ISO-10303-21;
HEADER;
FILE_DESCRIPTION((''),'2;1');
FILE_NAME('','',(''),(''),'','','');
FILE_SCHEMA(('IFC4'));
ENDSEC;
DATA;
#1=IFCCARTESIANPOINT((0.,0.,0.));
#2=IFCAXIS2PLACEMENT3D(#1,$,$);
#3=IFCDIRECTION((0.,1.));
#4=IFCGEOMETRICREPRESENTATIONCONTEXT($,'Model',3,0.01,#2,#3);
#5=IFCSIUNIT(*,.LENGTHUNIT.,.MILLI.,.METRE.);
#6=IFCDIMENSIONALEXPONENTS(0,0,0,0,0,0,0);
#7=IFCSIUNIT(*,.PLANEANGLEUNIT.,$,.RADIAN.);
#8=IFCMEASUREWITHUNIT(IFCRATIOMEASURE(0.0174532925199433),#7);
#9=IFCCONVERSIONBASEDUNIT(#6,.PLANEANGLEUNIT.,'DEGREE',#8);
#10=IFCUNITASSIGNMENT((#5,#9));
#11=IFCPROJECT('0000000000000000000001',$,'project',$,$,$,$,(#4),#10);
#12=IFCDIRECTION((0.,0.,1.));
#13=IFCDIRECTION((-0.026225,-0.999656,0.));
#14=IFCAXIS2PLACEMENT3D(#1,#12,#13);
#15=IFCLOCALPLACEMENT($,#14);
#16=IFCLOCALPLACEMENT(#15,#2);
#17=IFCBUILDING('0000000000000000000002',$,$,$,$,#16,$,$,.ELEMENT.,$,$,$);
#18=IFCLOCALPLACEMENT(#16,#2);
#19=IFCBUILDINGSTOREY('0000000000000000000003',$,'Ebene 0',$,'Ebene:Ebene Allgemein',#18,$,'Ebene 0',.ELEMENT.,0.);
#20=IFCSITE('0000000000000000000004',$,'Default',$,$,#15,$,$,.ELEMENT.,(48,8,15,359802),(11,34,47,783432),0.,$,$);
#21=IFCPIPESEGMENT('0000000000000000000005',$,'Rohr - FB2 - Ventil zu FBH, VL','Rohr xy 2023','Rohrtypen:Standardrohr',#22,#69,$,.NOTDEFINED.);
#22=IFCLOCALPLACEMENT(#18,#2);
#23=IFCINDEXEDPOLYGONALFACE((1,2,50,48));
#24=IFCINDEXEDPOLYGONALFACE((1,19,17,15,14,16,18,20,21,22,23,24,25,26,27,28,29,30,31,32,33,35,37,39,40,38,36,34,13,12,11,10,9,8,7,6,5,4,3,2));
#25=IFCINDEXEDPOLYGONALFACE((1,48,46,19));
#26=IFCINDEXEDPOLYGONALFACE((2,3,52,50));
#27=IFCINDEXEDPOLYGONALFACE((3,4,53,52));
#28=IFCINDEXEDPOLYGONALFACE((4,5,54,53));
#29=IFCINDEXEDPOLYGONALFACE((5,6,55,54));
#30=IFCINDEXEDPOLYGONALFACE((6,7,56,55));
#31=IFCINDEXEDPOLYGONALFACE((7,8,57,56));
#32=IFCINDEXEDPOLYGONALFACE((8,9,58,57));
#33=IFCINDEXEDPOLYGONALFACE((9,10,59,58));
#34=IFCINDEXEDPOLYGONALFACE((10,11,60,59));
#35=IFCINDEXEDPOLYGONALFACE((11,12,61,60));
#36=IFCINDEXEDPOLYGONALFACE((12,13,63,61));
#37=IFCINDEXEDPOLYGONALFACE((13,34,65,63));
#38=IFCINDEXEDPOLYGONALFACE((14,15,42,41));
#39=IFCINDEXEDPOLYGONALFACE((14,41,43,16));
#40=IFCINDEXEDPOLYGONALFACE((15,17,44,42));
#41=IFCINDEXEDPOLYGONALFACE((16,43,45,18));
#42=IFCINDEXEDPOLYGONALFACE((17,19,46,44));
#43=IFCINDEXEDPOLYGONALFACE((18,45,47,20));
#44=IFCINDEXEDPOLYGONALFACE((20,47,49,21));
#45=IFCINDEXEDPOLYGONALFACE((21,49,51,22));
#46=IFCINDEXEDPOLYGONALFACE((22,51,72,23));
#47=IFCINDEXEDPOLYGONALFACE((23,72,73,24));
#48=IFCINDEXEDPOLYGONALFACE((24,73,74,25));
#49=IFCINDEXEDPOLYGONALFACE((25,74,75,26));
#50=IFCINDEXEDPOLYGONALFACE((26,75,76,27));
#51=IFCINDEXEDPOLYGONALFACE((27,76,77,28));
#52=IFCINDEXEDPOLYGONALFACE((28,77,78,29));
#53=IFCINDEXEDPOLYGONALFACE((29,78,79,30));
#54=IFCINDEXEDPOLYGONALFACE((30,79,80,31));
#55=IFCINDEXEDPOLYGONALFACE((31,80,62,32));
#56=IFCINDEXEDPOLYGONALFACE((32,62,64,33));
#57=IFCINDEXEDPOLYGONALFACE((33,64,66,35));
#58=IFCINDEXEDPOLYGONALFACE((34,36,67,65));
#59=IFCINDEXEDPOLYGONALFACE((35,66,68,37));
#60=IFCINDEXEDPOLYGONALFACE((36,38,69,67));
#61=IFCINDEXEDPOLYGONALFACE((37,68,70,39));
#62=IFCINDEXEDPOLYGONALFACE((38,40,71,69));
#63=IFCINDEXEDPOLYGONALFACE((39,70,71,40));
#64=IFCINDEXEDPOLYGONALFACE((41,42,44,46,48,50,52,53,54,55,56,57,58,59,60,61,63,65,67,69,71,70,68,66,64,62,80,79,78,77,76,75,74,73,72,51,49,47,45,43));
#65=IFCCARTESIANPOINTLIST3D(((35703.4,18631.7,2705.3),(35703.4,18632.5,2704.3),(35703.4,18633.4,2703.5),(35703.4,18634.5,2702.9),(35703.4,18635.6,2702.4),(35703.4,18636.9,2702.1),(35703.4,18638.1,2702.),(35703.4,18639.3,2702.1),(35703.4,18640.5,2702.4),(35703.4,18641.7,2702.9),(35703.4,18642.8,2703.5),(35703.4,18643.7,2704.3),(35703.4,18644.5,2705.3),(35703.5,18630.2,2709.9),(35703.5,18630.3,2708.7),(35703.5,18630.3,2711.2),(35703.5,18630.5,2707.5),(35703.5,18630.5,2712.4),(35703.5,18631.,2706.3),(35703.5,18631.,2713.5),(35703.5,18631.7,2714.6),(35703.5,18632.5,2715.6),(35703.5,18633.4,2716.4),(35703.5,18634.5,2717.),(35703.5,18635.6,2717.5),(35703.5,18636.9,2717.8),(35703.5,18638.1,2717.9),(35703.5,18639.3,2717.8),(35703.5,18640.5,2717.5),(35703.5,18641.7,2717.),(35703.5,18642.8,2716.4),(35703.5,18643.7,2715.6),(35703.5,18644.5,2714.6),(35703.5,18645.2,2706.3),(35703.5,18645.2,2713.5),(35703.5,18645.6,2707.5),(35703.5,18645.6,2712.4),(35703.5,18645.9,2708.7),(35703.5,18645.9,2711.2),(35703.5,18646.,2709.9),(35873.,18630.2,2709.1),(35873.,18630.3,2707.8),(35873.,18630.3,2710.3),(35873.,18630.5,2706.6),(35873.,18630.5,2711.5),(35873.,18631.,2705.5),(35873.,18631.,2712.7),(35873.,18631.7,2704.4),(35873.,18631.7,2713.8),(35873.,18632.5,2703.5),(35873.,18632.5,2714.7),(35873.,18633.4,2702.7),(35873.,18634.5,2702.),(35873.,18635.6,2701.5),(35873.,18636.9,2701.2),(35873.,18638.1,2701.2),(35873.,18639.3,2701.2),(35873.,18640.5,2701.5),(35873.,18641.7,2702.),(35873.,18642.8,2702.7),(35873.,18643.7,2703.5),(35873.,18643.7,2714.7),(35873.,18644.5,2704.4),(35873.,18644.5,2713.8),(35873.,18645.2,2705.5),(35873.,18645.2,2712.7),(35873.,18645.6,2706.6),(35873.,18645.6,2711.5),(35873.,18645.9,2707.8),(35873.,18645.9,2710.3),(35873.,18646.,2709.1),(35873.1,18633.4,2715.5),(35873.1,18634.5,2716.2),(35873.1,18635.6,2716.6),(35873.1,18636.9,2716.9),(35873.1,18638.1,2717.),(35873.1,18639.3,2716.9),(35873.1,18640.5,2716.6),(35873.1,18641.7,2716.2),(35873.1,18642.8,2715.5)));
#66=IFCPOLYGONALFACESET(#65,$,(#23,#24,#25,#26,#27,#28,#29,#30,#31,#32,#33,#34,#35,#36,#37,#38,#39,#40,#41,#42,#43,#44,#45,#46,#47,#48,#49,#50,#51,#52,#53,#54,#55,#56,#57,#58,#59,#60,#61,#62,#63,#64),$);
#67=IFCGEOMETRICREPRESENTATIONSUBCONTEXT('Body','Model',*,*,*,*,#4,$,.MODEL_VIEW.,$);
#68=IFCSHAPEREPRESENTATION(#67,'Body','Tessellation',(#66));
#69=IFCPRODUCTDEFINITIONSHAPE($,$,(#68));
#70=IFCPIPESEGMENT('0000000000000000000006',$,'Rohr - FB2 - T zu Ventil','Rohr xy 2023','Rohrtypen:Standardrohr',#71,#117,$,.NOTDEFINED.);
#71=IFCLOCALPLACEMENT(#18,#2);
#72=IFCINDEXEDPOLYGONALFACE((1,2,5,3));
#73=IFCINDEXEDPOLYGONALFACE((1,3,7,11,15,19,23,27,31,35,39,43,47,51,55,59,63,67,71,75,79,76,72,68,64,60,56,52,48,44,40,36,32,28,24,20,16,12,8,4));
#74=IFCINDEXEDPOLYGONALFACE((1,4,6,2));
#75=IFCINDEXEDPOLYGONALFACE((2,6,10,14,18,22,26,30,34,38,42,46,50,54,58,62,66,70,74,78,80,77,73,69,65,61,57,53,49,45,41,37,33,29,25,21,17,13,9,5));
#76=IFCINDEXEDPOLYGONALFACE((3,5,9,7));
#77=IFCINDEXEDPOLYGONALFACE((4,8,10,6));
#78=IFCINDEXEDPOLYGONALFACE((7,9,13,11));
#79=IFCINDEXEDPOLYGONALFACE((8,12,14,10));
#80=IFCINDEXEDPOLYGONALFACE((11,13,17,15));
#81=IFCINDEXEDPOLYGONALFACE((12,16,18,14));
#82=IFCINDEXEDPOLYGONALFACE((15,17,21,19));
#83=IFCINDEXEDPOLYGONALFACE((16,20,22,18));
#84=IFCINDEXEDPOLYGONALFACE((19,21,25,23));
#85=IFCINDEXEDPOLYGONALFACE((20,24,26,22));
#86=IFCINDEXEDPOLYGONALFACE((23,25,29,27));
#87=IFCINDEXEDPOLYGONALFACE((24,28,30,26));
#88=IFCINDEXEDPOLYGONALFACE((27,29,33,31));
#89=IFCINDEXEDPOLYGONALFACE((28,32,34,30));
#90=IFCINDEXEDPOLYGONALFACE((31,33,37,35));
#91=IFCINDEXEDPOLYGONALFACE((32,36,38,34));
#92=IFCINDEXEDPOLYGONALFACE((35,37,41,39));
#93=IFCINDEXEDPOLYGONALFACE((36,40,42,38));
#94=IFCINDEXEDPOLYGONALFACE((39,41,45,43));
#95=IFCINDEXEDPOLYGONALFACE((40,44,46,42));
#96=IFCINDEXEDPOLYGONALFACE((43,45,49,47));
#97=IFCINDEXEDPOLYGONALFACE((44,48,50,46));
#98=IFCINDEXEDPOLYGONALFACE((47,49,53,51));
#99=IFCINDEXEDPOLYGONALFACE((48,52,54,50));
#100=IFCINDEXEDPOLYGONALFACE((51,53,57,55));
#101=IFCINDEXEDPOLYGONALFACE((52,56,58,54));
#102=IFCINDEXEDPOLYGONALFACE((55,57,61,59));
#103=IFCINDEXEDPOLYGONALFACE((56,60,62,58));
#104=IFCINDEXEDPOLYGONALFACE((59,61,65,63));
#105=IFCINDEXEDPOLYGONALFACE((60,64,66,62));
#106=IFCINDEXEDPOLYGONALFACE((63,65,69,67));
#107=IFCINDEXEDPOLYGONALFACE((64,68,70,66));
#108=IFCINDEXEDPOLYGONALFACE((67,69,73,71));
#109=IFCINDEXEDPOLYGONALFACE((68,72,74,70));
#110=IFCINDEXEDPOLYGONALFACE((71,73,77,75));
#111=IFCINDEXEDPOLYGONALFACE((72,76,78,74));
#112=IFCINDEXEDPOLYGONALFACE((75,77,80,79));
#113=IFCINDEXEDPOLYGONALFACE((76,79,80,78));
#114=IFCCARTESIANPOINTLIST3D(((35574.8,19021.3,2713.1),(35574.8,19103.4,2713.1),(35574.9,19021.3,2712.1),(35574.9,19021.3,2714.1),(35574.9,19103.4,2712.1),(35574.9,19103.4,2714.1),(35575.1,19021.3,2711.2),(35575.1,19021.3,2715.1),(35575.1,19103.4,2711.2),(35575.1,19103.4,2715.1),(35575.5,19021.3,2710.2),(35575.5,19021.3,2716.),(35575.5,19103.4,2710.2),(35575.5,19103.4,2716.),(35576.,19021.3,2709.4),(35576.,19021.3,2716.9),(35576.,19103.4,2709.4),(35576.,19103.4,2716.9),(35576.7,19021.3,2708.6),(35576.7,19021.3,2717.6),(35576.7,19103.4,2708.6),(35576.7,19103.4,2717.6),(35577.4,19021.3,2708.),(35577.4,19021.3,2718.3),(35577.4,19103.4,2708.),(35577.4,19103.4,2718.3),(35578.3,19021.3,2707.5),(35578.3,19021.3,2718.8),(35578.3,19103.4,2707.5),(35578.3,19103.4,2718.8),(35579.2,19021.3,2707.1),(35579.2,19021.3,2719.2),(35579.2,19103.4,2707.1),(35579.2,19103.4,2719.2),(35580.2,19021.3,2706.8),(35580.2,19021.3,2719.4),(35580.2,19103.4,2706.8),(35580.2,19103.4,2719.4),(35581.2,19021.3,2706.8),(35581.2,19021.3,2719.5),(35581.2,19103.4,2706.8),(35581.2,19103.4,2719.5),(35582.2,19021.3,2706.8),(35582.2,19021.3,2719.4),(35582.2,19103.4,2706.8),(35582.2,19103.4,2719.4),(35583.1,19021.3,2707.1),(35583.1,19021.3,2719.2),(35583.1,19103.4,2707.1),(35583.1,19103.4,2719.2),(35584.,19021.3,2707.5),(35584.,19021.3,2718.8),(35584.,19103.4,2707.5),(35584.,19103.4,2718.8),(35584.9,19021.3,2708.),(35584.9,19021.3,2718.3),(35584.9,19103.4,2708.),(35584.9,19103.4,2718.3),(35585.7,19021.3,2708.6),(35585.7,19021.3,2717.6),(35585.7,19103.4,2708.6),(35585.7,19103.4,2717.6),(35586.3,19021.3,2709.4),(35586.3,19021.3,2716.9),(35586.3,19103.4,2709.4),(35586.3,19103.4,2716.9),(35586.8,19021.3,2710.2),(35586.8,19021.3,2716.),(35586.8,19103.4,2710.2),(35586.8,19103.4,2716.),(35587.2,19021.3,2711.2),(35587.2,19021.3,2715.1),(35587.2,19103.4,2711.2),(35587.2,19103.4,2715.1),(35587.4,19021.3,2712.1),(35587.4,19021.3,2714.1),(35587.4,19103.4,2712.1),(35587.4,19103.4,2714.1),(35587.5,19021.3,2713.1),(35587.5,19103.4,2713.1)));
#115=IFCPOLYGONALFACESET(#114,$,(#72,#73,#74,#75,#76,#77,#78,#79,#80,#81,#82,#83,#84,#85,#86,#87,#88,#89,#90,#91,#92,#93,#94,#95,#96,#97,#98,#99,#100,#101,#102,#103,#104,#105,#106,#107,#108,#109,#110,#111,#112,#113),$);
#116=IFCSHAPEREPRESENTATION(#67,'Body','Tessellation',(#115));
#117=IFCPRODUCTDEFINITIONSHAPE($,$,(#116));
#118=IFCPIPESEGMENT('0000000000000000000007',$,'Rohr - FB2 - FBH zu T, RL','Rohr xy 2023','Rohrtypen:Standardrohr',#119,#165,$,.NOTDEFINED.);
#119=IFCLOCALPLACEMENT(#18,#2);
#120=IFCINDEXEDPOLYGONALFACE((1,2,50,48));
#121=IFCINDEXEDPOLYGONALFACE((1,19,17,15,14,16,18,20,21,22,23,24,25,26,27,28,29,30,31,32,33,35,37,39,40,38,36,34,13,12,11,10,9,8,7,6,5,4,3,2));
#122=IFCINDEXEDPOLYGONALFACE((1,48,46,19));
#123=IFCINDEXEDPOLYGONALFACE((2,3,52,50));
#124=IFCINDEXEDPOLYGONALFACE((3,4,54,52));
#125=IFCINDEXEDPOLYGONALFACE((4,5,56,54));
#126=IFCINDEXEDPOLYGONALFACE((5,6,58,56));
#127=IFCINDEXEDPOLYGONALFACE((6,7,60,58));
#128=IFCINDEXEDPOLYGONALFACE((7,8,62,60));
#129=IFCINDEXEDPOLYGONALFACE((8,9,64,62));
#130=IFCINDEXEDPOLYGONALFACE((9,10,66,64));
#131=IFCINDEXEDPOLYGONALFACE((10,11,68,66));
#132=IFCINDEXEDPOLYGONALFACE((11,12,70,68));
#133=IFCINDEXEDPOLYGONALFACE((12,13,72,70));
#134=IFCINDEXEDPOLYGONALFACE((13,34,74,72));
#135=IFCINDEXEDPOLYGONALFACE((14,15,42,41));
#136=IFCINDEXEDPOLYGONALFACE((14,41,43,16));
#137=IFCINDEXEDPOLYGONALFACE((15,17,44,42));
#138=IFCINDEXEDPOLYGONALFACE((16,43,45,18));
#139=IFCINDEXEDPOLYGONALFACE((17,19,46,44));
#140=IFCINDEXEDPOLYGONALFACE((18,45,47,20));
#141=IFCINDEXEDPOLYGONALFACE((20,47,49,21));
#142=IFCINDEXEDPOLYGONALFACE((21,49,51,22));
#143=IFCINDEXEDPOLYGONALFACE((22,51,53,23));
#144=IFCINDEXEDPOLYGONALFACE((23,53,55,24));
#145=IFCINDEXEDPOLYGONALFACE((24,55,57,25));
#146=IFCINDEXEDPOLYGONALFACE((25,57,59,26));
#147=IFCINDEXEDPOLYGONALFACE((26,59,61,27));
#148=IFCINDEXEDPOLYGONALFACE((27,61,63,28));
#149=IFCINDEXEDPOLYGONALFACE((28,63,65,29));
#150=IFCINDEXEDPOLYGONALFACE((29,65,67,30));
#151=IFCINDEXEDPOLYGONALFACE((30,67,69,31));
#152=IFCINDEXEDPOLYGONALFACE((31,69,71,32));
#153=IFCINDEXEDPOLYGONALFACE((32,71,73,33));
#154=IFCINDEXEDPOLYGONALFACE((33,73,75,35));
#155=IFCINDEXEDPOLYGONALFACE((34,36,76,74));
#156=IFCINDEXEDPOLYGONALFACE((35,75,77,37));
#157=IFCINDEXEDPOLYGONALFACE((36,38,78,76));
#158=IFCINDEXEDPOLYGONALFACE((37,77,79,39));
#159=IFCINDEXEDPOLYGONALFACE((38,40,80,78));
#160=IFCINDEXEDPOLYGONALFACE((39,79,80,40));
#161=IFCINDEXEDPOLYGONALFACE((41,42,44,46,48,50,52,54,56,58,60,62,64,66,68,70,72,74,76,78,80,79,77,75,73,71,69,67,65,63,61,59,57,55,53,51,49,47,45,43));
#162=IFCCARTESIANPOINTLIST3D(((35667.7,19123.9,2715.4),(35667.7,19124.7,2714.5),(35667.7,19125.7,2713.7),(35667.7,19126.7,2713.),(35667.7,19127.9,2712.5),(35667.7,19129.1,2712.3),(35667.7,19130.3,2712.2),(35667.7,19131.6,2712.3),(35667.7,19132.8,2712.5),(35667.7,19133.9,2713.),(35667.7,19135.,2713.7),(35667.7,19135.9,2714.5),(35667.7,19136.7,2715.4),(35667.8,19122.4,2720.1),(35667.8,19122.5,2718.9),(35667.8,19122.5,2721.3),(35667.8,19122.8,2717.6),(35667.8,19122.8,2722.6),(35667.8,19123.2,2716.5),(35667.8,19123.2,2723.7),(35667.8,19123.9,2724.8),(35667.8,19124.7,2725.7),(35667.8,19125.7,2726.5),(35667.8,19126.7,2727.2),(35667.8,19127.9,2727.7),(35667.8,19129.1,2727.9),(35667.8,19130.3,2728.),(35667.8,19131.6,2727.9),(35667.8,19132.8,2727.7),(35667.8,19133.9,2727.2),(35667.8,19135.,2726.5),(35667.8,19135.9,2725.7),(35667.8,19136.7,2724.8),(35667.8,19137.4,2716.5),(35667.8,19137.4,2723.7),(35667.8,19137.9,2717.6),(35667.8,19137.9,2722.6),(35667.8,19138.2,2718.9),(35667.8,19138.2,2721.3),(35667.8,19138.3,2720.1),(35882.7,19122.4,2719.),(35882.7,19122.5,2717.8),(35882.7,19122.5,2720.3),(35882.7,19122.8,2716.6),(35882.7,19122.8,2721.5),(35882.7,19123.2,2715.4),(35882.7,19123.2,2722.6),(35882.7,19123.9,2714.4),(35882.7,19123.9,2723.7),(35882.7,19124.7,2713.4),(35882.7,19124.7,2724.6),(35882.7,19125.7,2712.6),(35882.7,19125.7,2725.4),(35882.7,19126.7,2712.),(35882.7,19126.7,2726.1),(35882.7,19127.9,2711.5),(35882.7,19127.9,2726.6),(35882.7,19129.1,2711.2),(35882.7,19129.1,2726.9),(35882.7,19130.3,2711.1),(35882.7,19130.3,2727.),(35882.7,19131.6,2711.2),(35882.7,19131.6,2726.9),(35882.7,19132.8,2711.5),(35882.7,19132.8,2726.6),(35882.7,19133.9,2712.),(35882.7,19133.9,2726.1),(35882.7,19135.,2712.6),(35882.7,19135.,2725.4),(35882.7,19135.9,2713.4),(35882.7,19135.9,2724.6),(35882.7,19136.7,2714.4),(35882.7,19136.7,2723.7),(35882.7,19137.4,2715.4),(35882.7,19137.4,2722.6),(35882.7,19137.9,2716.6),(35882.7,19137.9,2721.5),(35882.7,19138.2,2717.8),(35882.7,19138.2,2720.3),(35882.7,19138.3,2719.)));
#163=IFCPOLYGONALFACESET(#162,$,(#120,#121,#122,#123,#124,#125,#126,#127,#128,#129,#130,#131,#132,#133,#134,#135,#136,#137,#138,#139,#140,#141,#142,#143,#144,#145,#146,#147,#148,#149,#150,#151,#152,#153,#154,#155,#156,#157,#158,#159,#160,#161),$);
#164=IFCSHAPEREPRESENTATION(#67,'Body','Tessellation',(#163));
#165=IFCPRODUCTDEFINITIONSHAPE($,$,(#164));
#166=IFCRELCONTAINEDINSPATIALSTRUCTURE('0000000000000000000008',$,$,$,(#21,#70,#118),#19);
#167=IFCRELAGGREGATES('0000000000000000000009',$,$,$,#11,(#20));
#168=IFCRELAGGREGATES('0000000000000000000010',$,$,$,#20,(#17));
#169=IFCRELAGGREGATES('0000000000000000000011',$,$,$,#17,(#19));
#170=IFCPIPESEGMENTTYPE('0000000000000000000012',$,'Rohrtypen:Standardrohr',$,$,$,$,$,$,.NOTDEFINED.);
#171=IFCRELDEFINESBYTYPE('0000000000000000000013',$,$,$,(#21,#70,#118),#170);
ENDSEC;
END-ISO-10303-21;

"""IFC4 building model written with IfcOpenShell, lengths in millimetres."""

from ifc_helpers import new_model, entity, si_unit, converted_unit, direction, frame, origin, place, context, subcontext, project, spatial, indexed_curve, outline, extrude, type_object, element, save


model = new_model("IFC4")

# Units and contexts
model_context = context("Model", 3, precision=0.01, world=origin(), true_north=direction((0.0, 1.0)))
body_context = subcontext(model_context, "Body", "Model", "MODEL_VIEW")
ifc_project = project(units=[si_unit("LENGTHUNIT", "METRE", prefix="MILLI"), converted_unit("PLANEANGLEUNIT", "DEGREE", entity("IfcRatioMeasure", 0.0174532925199433), si_unit("PLANEANGLEUNIT", "RADIAN"), dimensions=[0, 0, 0, 0, 0, 0, 0])], contexts=[model_context])

# Site, building, storey
site_placement = place(None, frame((0.0, 0.0, 0.0), z_axis=(0.0, 0.0, 1.0), x_axis=(-0.026225, -0.999656, 0.0)))
site = spatial("IfcSite", under=ifc_project, at=site_placement, Name="Default", CompositionType="ELEMENT", RefLatitude=(48, 8, 15, 359802), RefLongitude=(11, 34, 47, 783432), RefElevation=0.0)
building_placement = place(site_placement, origin())
building = spatial("IfcBuilding", under=site, at=building_placement, CompositionType="ELEMENT")
storey_placement = place(building_placement, origin())
storey = spatial("IfcBuildingStorey", under=building, at=storey_placement, Name="Ebene 0", ObjectType="Ebene:Ebene Allgemein", LongName="Ebene 0", CompositionType="ELEMENT", Elevation=0.0)

# Pipe segments
pipe_segment_type = type_object("IfcPipeSegmentType", Name="Rohrtypen:Standardrohr", PredefinedType="NOTDEFINED")
pipe_segment_1_placement = place(storey_placement, origin())
element("IfcPipeSegment", 1, at=pipe_segment_1_placement, inside=storey, type_object=pipe_segment_type, Name="Rohr - FB2 - Ventil zu FBH, VL", Description="Rohr xy 2023", ObjectType="Rohrtypen:Standardrohr", PredefinedType="NOTDEFINED", context=body_context, shape_type="SweptSolid", body=[
    extrude(outline(indexed_curve([(7.9, 0.0), (7.8, 1.2), (7.6, 2.5), (7.1, 3.6), (6.4, 4.7), (5.6, 5.6), (4.7, 6.4), (3.6, 7.1), (2.5, 7.6), (1.2, 7.8), (0.0, 7.9), (-1.2, 7.8), (-2.5, 7.6), (-3.6, 7.1), (-4.7, 6.4), (-5.6, 5.6), (-6.4, 4.7), (-7.1, 3.6), (-7.6, 2.5), (-7.8, 1.2), (-7.9, 0.0), (-7.8, -1.2), (-7.6, -2.5), (-7.1, -3.6), (-6.4, -4.7), (-5.6, -5.6), (-4.7, -6.4), (-3.6, -7.1), (-2.5, -7.6), (-1.2, -7.8), (0.0, -7.9), (1.2, -7.8), (2.5, -7.6), (3.6, -7.1), (4.7, -6.4), (5.6, -5.6), (6.4, -4.7), (7.1, -3.6), (7.6, -2.5), (7.8, -1.2), (7.9, 0.0)], self_intersect=False)), frame((35703.5, 18638.1, 2709.9), z_axis=(0.999988, 0.0, -0.005), x_axis=(0.0, 1.0, 0.0)), (0.0, 0.0, 1.0), 169.5),
])
pipe_segment_2_placement = place(storey_placement, origin())
element("IfcPipeSegment", 2, at=pipe_segment_2_placement, inside=storey, type_object=pipe_segment_type, Name="Rohr - FB2 - T zu Ventil", Description="Rohr xy 2023", ObjectType="Rohrtypen:Standardrohr", PredefinedType="NOTDEFINED", context=body_context, shape_type="SweptSolid", body=[
    extrude(outline(indexed_curve([(6.3, 0.0), (6.3, 1.0), (6.0, 2.0), (5.7, 2.9), (5.1, 3.7), (4.5, 4.5), (3.7, 5.1), (2.9, 5.7), (2.0, 6.0), (1.0, 6.3), (0.0, 6.4), (-1.0, 6.3), (-2.0, 6.0), (-2.9, 5.7), (-3.7, 5.1), (-4.5, 4.5), (-5.1, 3.7), (-5.7, 2.9), (-6.0, 2.0), (-6.3, 1.0), (-6.3, 0.0), (-6.3, -1.0), (-6.0, -2.0), (-5.7, -2.9), (-5.1, -3.7), (-4.5, -4.5), (-3.7, -5.1), (-2.9, -5.7), (-2.0, -6.0), (-1.0, -6.3), (0.0, -6.4), (1.0, -6.3), (2.0, -6.0), (2.9, -5.7), (3.7, -5.1), (4.5, -4.5), (5.1, -3.7), (5.7, -2.9), (6.0, -2.0), (6.3, -1.0), (6.3, 0.0)], self_intersect=False)), frame((35581.2, 19021.3, 2713.1), z_axis=(0.0, 1.0, 0.0), x_axis=(-1.0, 0.0, 0.0)), (0.0, 0.0, 1.0), 82.2),
])
pipe_segment_3_placement = place(storey_placement, origin())
element("IfcPipeSegment", 3, at=pipe_segment_3_placement, inside=storey, type_object=pipe_segment_type, Name="Rohr - FB2 - FBH zu T, RL", Description="Rohr xy 2023", ObjectType="Rohrtypen:Standardrohr", PredefinedType="NOTDEFINED", context=body_context, shape_type="SweptSolid", body=[
    extrude(outline(indexed_curve([(7.9, 0.0), (7.8, 1.2), (7.6, 2.5), (7.1, 3.6), (6.4, 4.7), (5.6, 5.6), (4.7, 6.4), (3.6, 7.1), (2.5, 7.6), (1.2, 7.8), (0.0, 7.9), (-1.2, 7.8), (-2.5, 7.6), (-3.6, 7.1), (-4.7, 6.4), (-5.6, 5.6), (-6.4, 4.7), (-7.1, 3.6), (-7.6, 2.5), (-7.8, 1.2), (-7.9, 0.0), (-7.8, -1.2), (-7.6, -2.5), (-7.1, -3.6), (-6.4, -4.7), (-5.6, -5.6), (-4.7, -6.4), (-3.6, -7.1), (-2.5, -7.6), (-1.2, -7.8), (0.0, -7.9), (1.2, -7.8), (2.5, -7.6), (3.6, -7.1), (4.7, -6.4), (5.6, -5.6), (6.4, -4.7), (7.1, -3.6), (7.6, -2.5), (7.8, -1.2), (7.9, 0.0)], self_intersect=False)), frame((35882.7, 19130.3, 2719.0), z_axis=(-0.999988, 0.0, 0.005), x_axis=(0.0, 1.0, 0.0)), (0.0, 0.0, 1.0), 214.9),
])

save(model, "model.ifc")
